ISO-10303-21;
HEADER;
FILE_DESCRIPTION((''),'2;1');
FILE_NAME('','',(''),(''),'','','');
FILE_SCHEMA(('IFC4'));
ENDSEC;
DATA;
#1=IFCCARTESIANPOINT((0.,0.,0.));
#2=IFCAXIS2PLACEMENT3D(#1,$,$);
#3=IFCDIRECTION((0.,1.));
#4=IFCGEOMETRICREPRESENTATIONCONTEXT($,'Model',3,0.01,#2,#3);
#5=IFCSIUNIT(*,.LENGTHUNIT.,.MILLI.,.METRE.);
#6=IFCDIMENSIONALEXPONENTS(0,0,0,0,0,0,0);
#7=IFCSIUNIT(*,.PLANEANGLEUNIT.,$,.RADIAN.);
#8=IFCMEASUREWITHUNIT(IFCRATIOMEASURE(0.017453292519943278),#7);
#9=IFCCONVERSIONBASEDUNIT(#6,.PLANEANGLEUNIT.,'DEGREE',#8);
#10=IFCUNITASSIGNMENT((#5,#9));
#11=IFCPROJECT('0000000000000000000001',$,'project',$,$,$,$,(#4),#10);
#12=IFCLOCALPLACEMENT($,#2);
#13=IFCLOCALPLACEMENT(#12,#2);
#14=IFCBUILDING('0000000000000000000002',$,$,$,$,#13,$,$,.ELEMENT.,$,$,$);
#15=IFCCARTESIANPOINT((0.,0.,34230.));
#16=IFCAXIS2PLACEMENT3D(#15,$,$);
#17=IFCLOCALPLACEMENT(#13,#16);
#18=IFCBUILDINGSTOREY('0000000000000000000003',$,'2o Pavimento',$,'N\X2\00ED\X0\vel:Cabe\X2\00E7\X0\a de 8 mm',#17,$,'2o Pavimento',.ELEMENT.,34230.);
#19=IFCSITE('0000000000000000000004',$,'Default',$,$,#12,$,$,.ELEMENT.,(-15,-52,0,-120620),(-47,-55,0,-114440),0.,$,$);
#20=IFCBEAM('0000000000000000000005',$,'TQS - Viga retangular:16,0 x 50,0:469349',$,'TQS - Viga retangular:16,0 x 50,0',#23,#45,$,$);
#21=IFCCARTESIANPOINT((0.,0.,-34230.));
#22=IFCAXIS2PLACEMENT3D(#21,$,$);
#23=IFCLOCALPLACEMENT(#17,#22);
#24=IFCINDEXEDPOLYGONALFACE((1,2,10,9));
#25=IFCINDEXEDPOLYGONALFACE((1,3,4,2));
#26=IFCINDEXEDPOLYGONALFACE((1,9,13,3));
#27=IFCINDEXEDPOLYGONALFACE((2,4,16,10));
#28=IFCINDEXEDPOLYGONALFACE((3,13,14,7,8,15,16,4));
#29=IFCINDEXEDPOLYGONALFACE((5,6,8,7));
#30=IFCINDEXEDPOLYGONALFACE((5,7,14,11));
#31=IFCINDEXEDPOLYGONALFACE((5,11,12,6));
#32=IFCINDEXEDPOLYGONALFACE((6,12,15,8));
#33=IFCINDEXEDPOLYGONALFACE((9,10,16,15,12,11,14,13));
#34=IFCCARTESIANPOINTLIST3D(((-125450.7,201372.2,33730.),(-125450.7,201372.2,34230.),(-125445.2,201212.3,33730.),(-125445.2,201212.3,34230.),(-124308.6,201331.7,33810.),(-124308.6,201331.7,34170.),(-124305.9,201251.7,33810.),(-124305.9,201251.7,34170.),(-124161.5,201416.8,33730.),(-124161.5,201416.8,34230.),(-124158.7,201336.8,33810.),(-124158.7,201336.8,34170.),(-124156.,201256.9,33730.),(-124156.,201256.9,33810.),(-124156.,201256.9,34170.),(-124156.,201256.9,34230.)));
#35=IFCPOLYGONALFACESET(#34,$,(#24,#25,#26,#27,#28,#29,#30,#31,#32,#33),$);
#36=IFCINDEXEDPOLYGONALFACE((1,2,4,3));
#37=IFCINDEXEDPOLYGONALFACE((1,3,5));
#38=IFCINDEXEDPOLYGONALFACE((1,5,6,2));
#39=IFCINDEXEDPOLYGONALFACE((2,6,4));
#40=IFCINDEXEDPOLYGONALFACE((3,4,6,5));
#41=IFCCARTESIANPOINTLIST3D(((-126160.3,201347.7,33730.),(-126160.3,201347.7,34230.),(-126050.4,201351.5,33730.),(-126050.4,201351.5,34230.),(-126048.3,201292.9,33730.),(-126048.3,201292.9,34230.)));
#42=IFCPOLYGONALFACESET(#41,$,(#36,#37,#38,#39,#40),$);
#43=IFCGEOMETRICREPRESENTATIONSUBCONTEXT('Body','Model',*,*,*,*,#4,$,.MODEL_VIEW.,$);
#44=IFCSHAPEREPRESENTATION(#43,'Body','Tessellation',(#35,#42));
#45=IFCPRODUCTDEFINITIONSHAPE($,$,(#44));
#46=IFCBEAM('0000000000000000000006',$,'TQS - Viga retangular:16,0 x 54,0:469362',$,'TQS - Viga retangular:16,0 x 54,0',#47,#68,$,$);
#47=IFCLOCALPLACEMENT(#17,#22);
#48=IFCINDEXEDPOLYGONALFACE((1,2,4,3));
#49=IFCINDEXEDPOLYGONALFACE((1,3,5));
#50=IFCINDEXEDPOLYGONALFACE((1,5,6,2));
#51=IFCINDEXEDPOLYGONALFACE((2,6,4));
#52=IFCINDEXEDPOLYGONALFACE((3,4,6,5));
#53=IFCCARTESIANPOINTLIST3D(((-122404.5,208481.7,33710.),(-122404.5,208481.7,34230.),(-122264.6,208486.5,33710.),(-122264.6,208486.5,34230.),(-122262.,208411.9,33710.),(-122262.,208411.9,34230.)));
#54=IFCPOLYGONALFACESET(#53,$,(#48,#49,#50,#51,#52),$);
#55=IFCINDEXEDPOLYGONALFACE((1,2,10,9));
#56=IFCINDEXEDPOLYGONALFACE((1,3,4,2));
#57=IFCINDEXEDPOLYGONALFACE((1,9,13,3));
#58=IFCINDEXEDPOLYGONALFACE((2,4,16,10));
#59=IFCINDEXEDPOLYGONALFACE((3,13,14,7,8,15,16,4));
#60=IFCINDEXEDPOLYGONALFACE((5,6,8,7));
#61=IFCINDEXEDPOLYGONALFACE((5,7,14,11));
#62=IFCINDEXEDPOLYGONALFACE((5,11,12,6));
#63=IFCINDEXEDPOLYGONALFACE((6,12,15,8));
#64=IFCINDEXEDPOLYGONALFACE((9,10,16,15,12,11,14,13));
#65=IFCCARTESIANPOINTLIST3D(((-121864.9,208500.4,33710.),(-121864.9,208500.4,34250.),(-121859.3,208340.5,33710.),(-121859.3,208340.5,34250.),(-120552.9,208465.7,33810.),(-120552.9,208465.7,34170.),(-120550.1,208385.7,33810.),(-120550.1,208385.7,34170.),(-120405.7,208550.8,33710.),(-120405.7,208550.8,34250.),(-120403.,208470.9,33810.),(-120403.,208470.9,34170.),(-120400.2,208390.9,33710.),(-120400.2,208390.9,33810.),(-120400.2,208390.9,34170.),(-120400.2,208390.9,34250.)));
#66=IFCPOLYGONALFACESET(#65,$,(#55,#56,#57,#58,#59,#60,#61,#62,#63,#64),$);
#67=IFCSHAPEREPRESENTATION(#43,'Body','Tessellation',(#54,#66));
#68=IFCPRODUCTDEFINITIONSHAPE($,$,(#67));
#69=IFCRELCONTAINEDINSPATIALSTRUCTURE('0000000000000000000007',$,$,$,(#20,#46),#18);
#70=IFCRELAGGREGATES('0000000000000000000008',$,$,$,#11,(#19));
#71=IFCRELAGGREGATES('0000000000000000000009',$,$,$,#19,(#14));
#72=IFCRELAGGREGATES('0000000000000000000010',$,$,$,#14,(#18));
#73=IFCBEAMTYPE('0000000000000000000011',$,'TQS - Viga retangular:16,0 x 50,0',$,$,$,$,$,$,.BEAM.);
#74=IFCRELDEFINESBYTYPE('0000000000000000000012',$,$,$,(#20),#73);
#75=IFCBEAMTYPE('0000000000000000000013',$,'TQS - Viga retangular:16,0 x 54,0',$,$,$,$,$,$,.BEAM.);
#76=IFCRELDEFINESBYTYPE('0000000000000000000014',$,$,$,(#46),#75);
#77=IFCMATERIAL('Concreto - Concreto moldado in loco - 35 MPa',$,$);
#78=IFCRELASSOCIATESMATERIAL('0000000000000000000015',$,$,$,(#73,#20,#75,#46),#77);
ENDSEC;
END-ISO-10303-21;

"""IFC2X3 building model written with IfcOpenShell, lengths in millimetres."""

from ifc_helpers import new_model, entity, si_unit, converted_unit, direction, frame, frame_2d, origin, origin_2d_with_axis, place, context, subcontext, project, spatial, polyline, rectangle, extrude, boolean, clip, halfspace, bounded_halfspace, source, transform, mapped, material, type_object, type_shapes, element, save


model = new_model("IFC2X3")

# Units and contexts
model_context = context("Model", 3, precision=0.01, world=origin(), true_north=direction((0.0, 1.0)))
body_context = subcontext(model_context, "Body", "Model", "MODEL_VIEW")
ifc_project = project(units=[si_unit("LENGTHUNIT", "METRE", prefix="MILLI"), converted_unit("PLANEANGLEUNIT", "DEGREE", entity("IfcRatioMeasure", 0.017453292519943278), si_unit("PLANEANGLEUNIT", "RADIAN"), dimensions=[0, 0, 0, 0, 0, 0, 0])], contexts=[model_context])

# Site, building, storey
site_placement = place(None, origin())
site = spatial("IfcSite", under=ifc_project, at=site_placement, Name="Default", CompositionType="ELEMENT", RefLatitude=(-15, -52, 0, -120620), RefLongitude=(-47, -55, 0, -114440), RefElevation=0.0)
building_placement = place(site_placement, origin())
building = spatial("IfcBuilding", under=site, at=building_placement, CompositionType="ELEMENT")
storey_placement = place(building_placement, frame((0.0, 0.0, 34230.0)))
storey = spatial("IfcBuildingStorey", under=building, at=storey_placement, Name="2o Pavimento", ObjectType="Nível:Cabeça de 8 mm", LongName="2o Pavimento", CompositionType="ELEMENT", Elevation=34230.0)

# Beams
ifc_material = material(Name="Concreto - Concreto moldado in loco - 35 MPa")
beam_type_1 = type_object("IfcBeamType", Name="TQS - Viga retangular:16,0 x 50,0", PredefinedType="BEAM", material=ifc_material)
shared_shape_1 = source(origin(), body_context, "Body", "SweptSolid", [
    boolean("DIFFERENCE", clip(extrude(rectangle(XDim=500.0, YDim=160.0, at=frame_2d((0.0, 0.0), x_axis=(1.0, 0.0))), frame((-124158.7, 201336.8, 33980.0), z_axis=(-0.999403, -0.034551, 0.0), x_axis=(0.0, 0.0, -1.0)), (0.0, 0.0, 1.0), 1290.0), bounded_halfspace(frame((-124308.6, 201331.7, 33810.0), z_axis=(0.999403, 0.034551, 0.0), x_axis=(0.034551, -0.999403, 0.0)), False, frame((-124158.7, 201336.8, 33980.0), z_axis=(-0.999403, -0.034551, 0.0), x_axis=(0.0, 0.0, -1.0)), polyline([(170.0, 0.0), (-190.0, 0.0), (-190.0, 80.0), (-90.0, 80.0), (170.0, 80.0), (170.0, 0.0)]))), extrude(rectangle(XDim=360.0, YDim=80.0, at=frame_2d((0.0, 0.0), x_axis=(0.0, 1.0))), frame((-124157.3, 201296.9, 33990.0), z_axis=(0.999403, 0.034551, 0.0), x_axis=(-0.034551, 0.999403, 0.0)), (0.0, 0.0, -1.0), 150.0)),
    clip(extrude(rectangle(XDim=500.0, YDim=58.7, at=frame_2d((0.0, 0.0), x_axis=(1.0, 0.0))), frame((-126049.3, 201322.2, 33980.0), z_axis=(-0.999403, -0.034551, 0.0), x_axis=(0.0, 0.0, -1.0)), (0.0, 0.0, 1.0), 110.0), halfspace(frame((-125854.9, 201198.1, 34230.0), z_axis=(-0.439821, -0.898085, 0.0), x_axis=(0.898085, -0.439821, 0.0)), False)),
])
type_shapes(beam_type_1, [shared_shape_1])
beam_1_placement = place(storey_placement, frame((0.0, 0.0, -34230.0)))
element("IfcBeam", 1, at=beam_1_placement, inside=storey, type_object=beam_type_1, material=ifc_material, Name="TQS - Viga retangular:16,0 x 50,0:469349", ObjectType="TQS - Viga retangular:16,0 x 50,0", context=body_context, shape_type="MappedRepresentation", body=[
    mapped(shared_shape_1, transform((0.0, 0.0, 0.0), scale=1.0)),
])
beam_type_2 = type_object("IfcBeamType", Name="TQS - Viga retangular:16,0 x 54,0", PredefinedType="BEAM", material=ifc_material)
shared_shape_2 = source(origin(), body_context, "Body", "SweptSolid", [
    clip(extrude(rectangle(XDim=520.0, YDim=74.7, at=frame_2d((0.0, 0.0), x_axis=(1.0, 0.0))), frame((-122263.3, 208449.2, 33970.0), z_axis=(-0.999403, -0.034551, 0.0), x_axis=(0.0, 0.0, -1.0)), (0.0, 0.0, 1.0), 140.0), halfspace(frame((-122099.2, 208332.2, 34250.0), z_axis=(-0.439821, -0.898085, 0.0), x_axis=(0.898085, -0.439821, 0.0)), False)),
    boolean("DIFFERENCE", clip(extrude(rectangle(XDim=540.0, YDim=160.0, at=origin_2d_with_axis()), frame((-120403.0, 208470.9, 33980.0), z_axis=(-0.999403, -0.034551, 0.0), x_axis=(0.0, 0.0, -1.0)), (0.0, 0.0, 1.0), 1460.0), bounded_halfspace(frame((-120552.9, 208465.7, 33810.0), z_axis=(0.999403, 0.034551, 0.0), x_axis=(0.034551, -0.999403, 0.0)), False, frame((-120403.0, 208470.9, 33980.0), z_axis=(-0.999403, -0.034551, 0.0), x_axis=(0.0, 0.0, -1.0)), polyline([(170.0, 0.0), (-190.0, 0.0), (-190.0, 80.0), (-90.0, 80.0), (170.0, 80.0), (170.0, 0.0)]))), extrude(rectangle(XDim=360.0, YDim=80.0, at=frame_2d((0.0, 0.0), x_axis=(0.0, 1.0))), frame((-120401.6, 208430.9, 33990.0), z_axis=(0.999403, 0.034551, 0.0), x_axis=(-0.034551, 0.999403, 0.0)), (0.0, 0.0, -1.0), 150.0)),
])
type_shapes(beam_type_2, [shared_shape_2])
beam_2_placement = place(storey_placement, frame((0.0, 0.0, -34230.0)))
element("IfcBeam", 2, at=beam_2_placement, inside=storey, type_object=beam_type_2, material=ifc_material, Name="TQS - Viga retangular:16,0 x 54,0:469362", ObjectType="TQS - Viga retangular:16,0 x 54,0", context=body_context, shape_type="MappedRepresentation", body=[
    mapped(shared_shape_2, transform((0.0, 0.0, 0.0), scale=1.0)),
])

save(model, "model.ifc")
